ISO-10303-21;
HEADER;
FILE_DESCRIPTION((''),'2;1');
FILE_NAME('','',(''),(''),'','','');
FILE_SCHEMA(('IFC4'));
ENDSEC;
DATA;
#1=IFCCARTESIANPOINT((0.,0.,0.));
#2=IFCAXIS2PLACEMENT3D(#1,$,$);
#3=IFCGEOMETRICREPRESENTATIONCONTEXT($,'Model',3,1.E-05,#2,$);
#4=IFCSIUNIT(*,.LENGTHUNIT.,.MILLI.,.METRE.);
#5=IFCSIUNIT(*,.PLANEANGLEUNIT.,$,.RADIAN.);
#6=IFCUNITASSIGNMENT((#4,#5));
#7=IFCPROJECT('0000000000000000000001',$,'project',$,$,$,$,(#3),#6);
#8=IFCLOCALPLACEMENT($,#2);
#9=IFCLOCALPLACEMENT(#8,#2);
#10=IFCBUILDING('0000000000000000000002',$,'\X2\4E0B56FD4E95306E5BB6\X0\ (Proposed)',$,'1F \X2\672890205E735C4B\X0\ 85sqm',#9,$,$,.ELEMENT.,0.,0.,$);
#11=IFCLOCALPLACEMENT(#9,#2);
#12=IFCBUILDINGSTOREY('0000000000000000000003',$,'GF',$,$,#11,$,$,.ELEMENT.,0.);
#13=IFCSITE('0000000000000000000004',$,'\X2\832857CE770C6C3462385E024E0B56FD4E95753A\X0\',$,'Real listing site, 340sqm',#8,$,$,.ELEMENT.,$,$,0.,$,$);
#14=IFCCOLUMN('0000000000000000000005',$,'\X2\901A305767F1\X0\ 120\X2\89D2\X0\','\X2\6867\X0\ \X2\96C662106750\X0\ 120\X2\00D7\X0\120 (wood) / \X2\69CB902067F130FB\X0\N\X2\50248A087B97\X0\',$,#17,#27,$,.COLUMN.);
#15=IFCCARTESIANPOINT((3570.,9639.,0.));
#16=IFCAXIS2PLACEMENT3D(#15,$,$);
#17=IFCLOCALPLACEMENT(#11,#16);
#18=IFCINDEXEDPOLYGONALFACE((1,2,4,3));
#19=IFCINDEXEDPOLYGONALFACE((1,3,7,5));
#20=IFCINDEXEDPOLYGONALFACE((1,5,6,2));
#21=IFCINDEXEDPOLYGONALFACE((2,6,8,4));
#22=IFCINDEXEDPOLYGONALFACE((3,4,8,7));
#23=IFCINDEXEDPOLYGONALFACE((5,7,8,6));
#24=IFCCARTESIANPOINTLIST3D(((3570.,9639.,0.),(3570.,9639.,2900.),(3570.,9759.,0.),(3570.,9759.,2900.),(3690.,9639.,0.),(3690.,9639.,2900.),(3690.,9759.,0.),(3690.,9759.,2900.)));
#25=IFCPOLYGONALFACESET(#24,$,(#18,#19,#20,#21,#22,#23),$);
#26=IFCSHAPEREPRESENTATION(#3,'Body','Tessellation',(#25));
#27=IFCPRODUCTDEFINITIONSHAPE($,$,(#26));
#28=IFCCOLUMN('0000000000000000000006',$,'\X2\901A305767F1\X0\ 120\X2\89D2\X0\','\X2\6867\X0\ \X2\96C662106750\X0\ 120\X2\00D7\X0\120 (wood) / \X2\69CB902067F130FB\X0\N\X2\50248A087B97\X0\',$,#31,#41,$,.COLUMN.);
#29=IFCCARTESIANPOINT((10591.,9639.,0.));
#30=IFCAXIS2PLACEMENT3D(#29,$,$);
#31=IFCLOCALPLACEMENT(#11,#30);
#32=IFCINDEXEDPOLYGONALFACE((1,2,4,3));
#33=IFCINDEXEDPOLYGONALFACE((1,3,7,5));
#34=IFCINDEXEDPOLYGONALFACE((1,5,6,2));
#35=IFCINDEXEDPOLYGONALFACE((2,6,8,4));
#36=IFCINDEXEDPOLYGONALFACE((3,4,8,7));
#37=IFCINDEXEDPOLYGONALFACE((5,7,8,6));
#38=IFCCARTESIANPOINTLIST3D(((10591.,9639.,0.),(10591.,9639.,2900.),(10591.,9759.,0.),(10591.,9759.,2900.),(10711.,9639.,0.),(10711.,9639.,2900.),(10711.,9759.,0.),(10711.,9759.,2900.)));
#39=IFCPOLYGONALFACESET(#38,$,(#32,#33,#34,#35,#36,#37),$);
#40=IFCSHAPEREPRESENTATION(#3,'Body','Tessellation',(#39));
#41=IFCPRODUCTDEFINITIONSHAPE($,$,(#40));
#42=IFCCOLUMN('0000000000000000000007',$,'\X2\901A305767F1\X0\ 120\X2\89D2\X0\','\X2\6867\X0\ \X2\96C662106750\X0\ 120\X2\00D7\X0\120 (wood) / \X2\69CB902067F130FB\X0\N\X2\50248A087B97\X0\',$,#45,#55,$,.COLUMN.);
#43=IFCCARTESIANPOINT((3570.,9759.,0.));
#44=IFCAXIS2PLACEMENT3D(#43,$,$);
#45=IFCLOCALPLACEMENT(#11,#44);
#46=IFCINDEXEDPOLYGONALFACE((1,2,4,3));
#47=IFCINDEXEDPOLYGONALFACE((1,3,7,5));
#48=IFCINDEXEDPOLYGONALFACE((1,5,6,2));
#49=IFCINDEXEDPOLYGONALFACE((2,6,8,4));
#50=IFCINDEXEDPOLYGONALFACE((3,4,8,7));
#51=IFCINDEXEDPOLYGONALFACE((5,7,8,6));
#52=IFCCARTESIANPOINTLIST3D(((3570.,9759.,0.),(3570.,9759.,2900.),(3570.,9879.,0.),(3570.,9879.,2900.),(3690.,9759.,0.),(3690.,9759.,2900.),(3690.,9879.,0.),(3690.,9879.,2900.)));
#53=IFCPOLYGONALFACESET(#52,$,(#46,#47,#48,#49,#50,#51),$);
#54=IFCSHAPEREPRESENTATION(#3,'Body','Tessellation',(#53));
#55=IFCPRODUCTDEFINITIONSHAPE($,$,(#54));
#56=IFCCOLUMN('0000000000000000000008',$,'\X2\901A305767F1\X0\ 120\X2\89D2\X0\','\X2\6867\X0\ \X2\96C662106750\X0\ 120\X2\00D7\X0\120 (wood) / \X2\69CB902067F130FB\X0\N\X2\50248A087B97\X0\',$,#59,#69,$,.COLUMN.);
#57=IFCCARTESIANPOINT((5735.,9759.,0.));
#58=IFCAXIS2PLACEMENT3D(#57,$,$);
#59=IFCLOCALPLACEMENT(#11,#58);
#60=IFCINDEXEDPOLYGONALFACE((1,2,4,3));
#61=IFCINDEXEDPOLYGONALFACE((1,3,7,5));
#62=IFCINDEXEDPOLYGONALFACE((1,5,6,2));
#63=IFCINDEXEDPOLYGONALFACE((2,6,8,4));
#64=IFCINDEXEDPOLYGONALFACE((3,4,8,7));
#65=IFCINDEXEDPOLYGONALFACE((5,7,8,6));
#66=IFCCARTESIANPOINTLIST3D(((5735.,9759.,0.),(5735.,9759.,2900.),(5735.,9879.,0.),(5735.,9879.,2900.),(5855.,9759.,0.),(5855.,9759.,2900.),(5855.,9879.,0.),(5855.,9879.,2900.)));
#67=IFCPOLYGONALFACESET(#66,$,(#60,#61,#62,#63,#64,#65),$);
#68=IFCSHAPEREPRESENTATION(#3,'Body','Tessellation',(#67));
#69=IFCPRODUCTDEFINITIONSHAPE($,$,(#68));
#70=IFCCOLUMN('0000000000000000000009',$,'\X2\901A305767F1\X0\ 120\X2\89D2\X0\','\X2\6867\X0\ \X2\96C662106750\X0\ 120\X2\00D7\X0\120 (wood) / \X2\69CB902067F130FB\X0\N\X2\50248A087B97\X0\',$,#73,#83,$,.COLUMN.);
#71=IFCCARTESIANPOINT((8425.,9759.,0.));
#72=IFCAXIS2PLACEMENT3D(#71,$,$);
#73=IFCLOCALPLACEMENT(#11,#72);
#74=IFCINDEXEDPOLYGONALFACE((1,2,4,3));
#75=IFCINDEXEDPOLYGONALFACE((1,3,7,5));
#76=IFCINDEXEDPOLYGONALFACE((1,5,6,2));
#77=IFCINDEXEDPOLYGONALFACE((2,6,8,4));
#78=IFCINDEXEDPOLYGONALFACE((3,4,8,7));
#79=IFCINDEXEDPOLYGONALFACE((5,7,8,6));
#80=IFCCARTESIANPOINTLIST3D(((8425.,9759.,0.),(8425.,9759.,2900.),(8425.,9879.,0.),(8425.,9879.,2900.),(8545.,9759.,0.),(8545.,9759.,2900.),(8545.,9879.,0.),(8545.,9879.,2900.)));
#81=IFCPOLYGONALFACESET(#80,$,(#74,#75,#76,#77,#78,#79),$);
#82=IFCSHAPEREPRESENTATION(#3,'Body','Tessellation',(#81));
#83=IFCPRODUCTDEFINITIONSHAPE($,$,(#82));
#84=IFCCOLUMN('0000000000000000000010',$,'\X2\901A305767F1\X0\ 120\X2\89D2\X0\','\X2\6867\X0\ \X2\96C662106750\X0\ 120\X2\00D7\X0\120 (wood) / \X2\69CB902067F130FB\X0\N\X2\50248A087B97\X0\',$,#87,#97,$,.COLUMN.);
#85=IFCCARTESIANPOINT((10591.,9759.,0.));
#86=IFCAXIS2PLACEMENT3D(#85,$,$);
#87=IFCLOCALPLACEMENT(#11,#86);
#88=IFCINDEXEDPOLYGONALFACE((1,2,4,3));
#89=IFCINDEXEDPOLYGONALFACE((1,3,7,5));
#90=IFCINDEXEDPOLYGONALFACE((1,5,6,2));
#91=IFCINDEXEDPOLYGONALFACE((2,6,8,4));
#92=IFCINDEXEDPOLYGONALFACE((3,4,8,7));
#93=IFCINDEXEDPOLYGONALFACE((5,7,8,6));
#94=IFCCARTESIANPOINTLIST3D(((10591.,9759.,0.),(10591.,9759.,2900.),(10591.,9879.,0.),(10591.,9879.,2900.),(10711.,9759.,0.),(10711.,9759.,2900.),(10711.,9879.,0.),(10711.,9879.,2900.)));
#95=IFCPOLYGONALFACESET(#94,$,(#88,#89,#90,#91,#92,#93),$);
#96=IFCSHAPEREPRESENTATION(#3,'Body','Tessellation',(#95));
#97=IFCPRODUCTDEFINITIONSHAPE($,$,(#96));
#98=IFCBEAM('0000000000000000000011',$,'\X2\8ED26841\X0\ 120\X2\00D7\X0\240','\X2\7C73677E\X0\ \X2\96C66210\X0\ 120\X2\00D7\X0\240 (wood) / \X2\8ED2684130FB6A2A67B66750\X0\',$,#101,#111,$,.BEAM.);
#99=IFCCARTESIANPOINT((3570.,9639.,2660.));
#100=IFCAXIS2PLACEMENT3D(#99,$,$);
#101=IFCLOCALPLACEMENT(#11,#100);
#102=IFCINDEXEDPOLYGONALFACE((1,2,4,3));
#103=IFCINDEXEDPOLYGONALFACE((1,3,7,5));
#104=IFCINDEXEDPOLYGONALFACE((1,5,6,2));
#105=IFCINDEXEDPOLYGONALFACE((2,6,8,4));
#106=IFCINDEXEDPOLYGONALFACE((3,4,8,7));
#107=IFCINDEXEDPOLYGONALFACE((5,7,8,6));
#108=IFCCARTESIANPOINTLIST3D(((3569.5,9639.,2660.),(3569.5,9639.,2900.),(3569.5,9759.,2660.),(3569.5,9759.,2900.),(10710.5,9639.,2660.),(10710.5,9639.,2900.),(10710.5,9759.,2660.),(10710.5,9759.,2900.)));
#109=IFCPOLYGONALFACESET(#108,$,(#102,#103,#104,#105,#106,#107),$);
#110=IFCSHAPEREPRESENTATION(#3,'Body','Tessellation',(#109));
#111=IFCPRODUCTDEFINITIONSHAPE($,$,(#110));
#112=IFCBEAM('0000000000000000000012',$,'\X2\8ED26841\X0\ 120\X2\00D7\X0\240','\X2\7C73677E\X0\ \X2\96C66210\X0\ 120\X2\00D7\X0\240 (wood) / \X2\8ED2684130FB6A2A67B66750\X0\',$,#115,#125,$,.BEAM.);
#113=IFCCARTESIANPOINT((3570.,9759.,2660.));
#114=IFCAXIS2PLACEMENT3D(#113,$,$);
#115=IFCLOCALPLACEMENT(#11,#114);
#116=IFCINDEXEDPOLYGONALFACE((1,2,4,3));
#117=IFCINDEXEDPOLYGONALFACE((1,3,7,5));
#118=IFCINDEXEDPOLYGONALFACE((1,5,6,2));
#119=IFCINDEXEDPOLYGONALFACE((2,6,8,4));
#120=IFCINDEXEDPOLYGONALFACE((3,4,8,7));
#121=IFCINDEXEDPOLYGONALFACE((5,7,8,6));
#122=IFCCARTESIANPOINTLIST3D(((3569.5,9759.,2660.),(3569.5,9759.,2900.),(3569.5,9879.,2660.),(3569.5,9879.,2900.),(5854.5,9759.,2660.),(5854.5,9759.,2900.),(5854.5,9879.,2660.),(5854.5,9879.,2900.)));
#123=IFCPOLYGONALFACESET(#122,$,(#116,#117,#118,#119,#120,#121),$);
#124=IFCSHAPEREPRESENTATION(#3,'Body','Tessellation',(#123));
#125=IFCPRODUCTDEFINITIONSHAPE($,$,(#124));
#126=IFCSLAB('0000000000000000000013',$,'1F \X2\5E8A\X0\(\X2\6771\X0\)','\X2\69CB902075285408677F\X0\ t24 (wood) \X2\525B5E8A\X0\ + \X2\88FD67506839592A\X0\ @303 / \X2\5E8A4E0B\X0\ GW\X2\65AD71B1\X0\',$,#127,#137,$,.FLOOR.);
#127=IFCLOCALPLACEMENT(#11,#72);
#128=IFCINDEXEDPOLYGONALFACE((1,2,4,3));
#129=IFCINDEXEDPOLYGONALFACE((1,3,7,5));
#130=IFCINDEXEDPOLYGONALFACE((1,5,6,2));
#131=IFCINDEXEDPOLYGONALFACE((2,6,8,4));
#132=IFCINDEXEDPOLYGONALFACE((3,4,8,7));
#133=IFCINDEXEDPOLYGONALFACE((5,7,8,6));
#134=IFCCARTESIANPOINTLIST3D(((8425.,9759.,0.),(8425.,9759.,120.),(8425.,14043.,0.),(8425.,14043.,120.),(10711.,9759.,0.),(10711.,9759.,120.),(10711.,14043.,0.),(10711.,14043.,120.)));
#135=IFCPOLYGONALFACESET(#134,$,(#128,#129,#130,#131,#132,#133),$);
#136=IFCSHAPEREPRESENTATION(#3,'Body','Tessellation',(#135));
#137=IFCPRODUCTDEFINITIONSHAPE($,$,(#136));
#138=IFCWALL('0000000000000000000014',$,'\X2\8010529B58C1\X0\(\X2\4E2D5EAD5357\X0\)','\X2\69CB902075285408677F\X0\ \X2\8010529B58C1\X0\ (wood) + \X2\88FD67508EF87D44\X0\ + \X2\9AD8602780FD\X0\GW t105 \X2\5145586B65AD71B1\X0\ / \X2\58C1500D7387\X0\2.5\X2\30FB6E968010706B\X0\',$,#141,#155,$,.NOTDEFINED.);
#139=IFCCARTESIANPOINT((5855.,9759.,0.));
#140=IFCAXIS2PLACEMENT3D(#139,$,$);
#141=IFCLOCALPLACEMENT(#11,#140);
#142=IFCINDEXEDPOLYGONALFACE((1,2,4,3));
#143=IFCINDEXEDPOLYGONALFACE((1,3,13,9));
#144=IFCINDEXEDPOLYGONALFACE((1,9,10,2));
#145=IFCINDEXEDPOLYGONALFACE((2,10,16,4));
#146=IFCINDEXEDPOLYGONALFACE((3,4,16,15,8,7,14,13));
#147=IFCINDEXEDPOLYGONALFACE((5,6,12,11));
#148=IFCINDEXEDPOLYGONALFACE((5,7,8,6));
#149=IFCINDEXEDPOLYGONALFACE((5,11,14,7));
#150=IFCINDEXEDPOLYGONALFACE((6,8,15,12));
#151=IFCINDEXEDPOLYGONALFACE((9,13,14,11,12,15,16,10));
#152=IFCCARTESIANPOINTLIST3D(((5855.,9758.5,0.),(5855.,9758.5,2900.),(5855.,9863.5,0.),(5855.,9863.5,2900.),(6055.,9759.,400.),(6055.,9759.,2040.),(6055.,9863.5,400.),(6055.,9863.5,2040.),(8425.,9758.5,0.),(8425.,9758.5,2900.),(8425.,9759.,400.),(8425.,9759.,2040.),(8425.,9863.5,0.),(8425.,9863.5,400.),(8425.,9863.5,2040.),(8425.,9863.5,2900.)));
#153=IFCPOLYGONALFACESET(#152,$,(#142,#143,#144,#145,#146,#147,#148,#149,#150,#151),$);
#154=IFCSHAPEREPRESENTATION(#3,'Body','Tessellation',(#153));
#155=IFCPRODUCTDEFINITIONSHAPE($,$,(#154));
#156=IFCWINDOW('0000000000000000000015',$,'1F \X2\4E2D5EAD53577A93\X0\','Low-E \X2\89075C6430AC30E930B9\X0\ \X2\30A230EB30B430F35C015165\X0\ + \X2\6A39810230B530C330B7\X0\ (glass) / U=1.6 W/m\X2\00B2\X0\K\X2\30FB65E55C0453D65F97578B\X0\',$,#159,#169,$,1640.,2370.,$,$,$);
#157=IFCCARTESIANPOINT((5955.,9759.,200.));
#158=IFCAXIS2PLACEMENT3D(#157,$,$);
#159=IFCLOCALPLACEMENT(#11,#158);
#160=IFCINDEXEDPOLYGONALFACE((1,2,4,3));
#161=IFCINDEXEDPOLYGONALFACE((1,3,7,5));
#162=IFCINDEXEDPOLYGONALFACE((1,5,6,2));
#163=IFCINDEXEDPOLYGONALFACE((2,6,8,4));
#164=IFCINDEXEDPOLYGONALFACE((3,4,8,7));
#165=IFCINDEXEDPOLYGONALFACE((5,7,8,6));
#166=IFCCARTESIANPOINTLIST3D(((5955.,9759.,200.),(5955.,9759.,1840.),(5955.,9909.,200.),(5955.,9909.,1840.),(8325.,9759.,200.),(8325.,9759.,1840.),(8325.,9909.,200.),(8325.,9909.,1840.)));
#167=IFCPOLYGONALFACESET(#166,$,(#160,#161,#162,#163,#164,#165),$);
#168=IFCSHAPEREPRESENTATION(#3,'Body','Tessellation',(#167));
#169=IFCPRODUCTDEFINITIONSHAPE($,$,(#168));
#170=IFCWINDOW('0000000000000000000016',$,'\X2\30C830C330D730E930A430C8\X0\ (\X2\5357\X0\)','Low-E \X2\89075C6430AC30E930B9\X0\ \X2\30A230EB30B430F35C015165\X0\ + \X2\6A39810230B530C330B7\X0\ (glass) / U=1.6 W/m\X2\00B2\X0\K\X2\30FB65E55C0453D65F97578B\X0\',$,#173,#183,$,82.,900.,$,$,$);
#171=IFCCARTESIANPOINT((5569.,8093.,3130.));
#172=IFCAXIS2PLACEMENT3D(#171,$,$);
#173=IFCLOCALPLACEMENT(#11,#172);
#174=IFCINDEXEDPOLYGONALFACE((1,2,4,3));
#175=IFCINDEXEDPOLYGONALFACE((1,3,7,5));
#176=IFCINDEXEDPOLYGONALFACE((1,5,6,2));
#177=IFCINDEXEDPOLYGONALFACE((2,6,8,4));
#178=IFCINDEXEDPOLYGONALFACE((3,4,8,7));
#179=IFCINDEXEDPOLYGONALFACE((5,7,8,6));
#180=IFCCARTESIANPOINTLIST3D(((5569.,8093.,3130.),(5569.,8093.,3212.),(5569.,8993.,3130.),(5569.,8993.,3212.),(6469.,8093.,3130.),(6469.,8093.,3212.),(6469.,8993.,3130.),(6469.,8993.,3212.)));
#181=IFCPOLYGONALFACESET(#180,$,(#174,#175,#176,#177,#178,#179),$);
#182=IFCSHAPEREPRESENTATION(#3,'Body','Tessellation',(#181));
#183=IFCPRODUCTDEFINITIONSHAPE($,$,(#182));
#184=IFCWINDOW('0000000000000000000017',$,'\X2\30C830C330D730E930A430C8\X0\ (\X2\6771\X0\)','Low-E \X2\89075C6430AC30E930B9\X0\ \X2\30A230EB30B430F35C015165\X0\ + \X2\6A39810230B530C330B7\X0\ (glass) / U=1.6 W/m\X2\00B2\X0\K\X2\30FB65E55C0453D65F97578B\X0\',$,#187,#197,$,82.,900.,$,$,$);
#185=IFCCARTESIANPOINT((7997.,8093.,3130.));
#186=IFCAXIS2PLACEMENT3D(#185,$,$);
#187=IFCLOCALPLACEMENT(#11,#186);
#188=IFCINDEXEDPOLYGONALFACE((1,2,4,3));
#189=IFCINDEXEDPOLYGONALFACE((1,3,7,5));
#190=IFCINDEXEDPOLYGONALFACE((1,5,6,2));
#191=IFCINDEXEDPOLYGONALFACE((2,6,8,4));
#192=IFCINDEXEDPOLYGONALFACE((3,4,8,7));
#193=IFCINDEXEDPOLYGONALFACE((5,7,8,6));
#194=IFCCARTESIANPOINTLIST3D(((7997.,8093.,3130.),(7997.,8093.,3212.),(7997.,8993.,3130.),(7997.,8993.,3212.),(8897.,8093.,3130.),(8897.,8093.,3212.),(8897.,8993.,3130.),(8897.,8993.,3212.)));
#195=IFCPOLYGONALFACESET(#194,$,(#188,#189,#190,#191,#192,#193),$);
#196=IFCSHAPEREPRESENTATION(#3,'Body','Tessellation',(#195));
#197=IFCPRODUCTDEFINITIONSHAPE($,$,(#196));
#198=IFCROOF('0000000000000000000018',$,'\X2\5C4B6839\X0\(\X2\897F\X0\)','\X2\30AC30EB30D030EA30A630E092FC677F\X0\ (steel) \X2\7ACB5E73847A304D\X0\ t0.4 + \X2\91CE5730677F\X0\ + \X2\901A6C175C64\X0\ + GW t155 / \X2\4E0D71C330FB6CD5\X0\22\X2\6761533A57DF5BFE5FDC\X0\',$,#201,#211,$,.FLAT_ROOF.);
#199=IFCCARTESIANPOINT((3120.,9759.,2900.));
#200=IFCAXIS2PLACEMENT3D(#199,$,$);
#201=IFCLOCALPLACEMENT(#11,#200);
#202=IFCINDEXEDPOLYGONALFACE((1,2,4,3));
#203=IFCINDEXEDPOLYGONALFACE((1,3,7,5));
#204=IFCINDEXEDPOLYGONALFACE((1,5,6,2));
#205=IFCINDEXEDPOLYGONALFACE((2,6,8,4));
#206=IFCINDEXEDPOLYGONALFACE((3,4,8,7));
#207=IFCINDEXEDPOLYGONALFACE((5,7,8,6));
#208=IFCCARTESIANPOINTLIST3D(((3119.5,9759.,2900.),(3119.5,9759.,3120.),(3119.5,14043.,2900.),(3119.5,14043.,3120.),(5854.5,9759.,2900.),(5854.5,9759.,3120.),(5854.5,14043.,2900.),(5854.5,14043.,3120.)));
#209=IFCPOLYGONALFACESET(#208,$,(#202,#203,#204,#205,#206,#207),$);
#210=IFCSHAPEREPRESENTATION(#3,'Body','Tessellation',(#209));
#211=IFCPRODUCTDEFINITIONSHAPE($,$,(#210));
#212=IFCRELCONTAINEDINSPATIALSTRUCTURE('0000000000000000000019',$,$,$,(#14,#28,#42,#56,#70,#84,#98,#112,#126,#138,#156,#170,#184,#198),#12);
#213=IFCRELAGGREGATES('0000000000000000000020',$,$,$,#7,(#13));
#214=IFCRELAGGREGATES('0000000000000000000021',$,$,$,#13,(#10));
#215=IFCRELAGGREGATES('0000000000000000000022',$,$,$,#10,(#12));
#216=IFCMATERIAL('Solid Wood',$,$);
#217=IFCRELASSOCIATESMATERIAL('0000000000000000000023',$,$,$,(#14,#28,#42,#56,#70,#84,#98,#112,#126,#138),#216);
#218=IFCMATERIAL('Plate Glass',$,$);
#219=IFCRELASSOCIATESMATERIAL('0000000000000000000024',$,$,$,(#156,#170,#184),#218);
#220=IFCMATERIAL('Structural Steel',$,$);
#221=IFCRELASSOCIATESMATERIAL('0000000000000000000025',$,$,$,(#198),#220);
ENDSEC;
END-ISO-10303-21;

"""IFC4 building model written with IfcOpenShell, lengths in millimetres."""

from ifc_helpers import new_model, si_unit, frame, frame_2d, origin, place, context, project, spatial, rectangle, extrude, material, element, fill, save


model = new_model("IFC4")

# Units and contexts
model_context = context("Model", 3, precision=1e-05, world=origin())
ifc_project = project(units=[si_unit("LENGTHUNIT", "METRE", prefix="MILLI"), si_unit("PLANEANGLEUNIT", "RADIAN")], contexts=[model_context])

# Site, building, storey
site_placement = place(None, origin())
site = spatial("IfcSite", under=ifc_project, at=site_placement, Name="茨城県水戸市下国井町", ObjectType="Real listing site, 340sqm", CompositionType="ELEMENT", RefElevation=0.0)
building_placement = place(site_placement, origin())
building = spatial("IfcBuilding", under=site, at=building_placement, Name="下国井の家 (Proposed)", ObjectType="1F 木造平屋 85sqm", CompositionType="ELEMENT", ElevationOfRefHeight=0.0, ElevationOfTerrain=0.0)
storey_placement = place(building_placement, origin())
storey = spatial("IfcBuildingStorey", under=building, at=storey_placement, Name="GF", CompositionType="ELEMENT", Elevation=0.0)

# Columns
ifc_material_1 = material(Name="Solid Wood")
column_1_placement = place(storey_placement, frame((3570.0, 9639.0, 0.0)))
element("IfcColumn", 1, at=column_1_placement, inside=storey, material=ifc_material_1, Name="通し柱 120角", Description="桧 集成材 120×120 (wood) / 構造柱・N値計算", PredefinedType="COLUMN", context=model_context, shape_type="SweptSolid", body=[
    extrude(rectangle(XDim=120.0, YDim=120.0, at=frame_2d((60.0, 60.0))), frame((3570.0, 9639.0, 0.0)), (0.0, 0.0, 1.0), 2900.0),
])
column_2_placement = place(storey_placement, frame((10591.0, 9639.0, 0.0)))
element("IfcColumn", 2, at=column_2_placement, inside=storey, material=ifc_material_1, Name="通し柱 120角", Description="桧 集成材 120×120 (wood) / 構造柱・N値計算", PredefinedType="COLUMN", context=model_context, shape_type="SweptSolid", body=[
    extrude(rectangle(XDim=120.0, YDim=120.0, at=frame_2d((60.0, 60.0))), frame((10591.0, 9639.0, 0.0)), (0.0, 0.0, 1.0), 2900.0),
])
column_3_placement = place(storey_placement, frame((3570.0, 9759.0, 0.0)))
element("IfcColumn", 3, at=column_3_placement, inside=storey, material=ifc_material_1, Name="通し柱 120角", Description="桧 集成材 120×120 (wood) / 構造柱・N値計算", PredefinedType="COLUMN", context=model_context, shape_type="SweptSolid", body=[
    extrude(rectangle(XDim=120.0, YDim=120.0, at=frame_2d((60.0, 60.0))), frame((3570.0, 9759.0, 0.0)), (0.0, 0.0, 1.0), 2900.0),
])
column_4_placement = place(storey_placement, frame((5735.0, 9759.0, 0.0)))
element("IfcColumn", 4, at=column_4_placement, inside=storey, material=ifc_material_1, Name="通し柱 120角", Description="桧 集成材 120×120 (wood) / 構造柱・N値計算", PredefinedType="COLUMN", context=model_context, shape_type="SweptSolid", body=[
    extrude(rectangle(XDim=120.0, YDim=120.0, at=frame_2d((60.0, 60.0))), frame((5735.0, 9759.0, 0.0)), (0.0, 0.0, 1.0), 2900.0),
])
column_5_placement = place(storey_placement, frame((8425.0, 9759.0, 0.0)))
element("IfcColumn", 5, at=column_5_placement, inside=storey, material=ifc_material_1, Name="通し柱 120角", Description="桧 集成材 120×120 (wood) / 構造柱・N値計算", PredefinedType="COLUMN", context=model_context, shape_type="SweptSolid", body=[
    extrude(rectangle(XDim=120.0, YDim=120.0, at=frame_2d((60.0, 60.0))), frame((8425.0, 9759.0, 0.0)), (0.0, 0.0, 1.0), 2900.0),
])
column_6_placement = place(storey_placement, frame((10591.0, 9759.0, 0.0)))
element("IfcColumn", 6, at=column_6_placement, inside=storey, material=ifc_material_1, Name="通し柱 120角", Description="桧 集成材 120×120 (wood) / 構造柱・N値計算", PredefinedType="COLUMN", context=model_context, shape_type="SweptSolid", body=[
    extrude(rectangle(XDim=120.0, YDim=120.0, at=frame_2d((60.0, 60.0))), frame((10591.0, 9759.0, 0.0)), (0.0, 0.0, 1.0), 2900.0),
])

# Beams
beam_1_placement = place(storey_placement, frame((3570.0, 9639.0, 2660.0)))
element("IfcBeam", 7, at=beam_1_placement, inside=storey, material=ifc_material_1, Name="軒桁 120×240", Description="米松 集成 120×240 (wood) / 軒桁・横架材", PredefinedType="BEAM", context=model_context, shape_type="SweptSolid", body=[
    extrude(rectangle(XDim=7141.0, YDim=120.0, at=frame_2d((3570.0, 60.0))), frame((3570.0, 9639.0, 2660.0)), (0.0, 0.0, 1.0), 240.0),
])
beam_2_placement = place(storey_placement, frame((3570.0, 9759.0, 2660.0)))
element("IfcBeam", 8, at=beam_2_placement, inside=storey, material=ifc_material_1, Name="軒桁 120×240", Description="米松 集成 120×240 (wood) / 軒桁・横架材", PredefinedType="BEAM", context=model_context, shape_type="SweptSolid", body=[
    extrude(rectangle(XDim=2285.0, YDim=120.0, at=frame_2d((1142.0, 60.0))), frame((3570.0, 9759.0, 2660.0)), (0.0, 0.0, 1.0), 240.0),
])

# Slab
slab_1_placement = place(storey_placement, frame((8425.0, 9759.0, 0.0)))
element("IfcSlab", 9, at=slab_1_placement, inside=storey, material=ifc_material_1, Name="1F 床(東)", Description="構造用合板 t24 (wood) 剛床 + 製材根太 @303 / 床下 GW断熱", PredefinedType="FLOOR", context=model_context, shape_type="SweptSolid", body=[
    extrude(rectangle(XDim=2286.0, YDim=4284.0, at=frame_2d((1143.0, 2142.0))), frame((8425.0, 9759.0, 0.0)), (0.0, 0.0, 1.0), 120.0),
])

# Wall, opening, window
wall_1_placement = place(storey_placement, frame((5855.0, 9759.0, 0.0)))
wall_1 = element("IfcWall", 10, at=wall_1_placement, inside=storey, material=ifc_material_1, Name="耐力壁(中庭南)", Description="構造用合板 耐力壁 (wood) + 製材軸組 + 高性能GW t105 充填断熱 / 壁倍率2.5・準耐火", PredefinedType="NOTDEFINED", context=model_context, shape_type="SweptSolid", body=[
    extrude(rectangle(XDim=2570.0, YDim=105.0, at=frame_2d((1285.0, 52.0))), frame((5855.0, 9759.0, 0.0)), (0.0, 0.0, 1.0), 2900.0),
])
opening_placement = place(storey_placement, frame((5955.0, 9759.0, 200.0)))
opening = element("IfcOpeningElement", 11, at=opening_placement, cuts=wall_1, PredefinedType="NOTDEFINED", context=model_context, shape_type="SweptSolid", body=[
    extrude(rectangle(XDim=2370.0, YDim=150.0, at=frame_2d((1185.0, 75.0))), frame((5955.0, 9759.0, 200.0)), (0.0, 0.0, 1.0), 1640.0),
])
ifc_material_2 = material(Name="Plate Glass")
window_1_placement = place(storey_placement, frame((5955.0, 9759.0, 200.0)))
window_1 = element("IfcWindow", 12, at=window_1_placement, inside=storey, material=ifc_material_2, Name="1F 中庭南窓", Description="Low-E 複層ガラス アルゴン封入 + 樹脂サッシ (glass) / U=1.6 W/m²K・日射取得型", OverallHeight=1640.0, OverallWidth=2370.0, context=model_context, shape_type="SweptSolid", body=[
    extrude(rectangle(XDim=2370.0, YDim=150.0, at=frame_2d((1185.0, 75.0))), frame((5955.0, 9759.0, 200.0)), (0.0, 0.0, 1.0), 1640.0),
])
fill(opening, window_1)

# Windows
window_2_placement = place(storey_placement, frame((5569.0, 8093.0, 3130.0)))
element("IfcWindow", 13, at=window_2_placement, inside=storey, material=ifc_material_2, Name="トップライト (南)", Description="Low-E 複層ガラス アルゴン封入 + 樹脂サッシ (glass) / U=1.6 W/m²K・日射取得型", OverallHeight=82.0, OverallWidth=900.0, context=model_context, shape_type="SweptSolid", body=[
    extrude(rectangle(XDim=900.0, YDim=900.0, at=frame_2d((450.0, 450.0))), frame((5569.0, 8093.0, 3130.0)), (0.0, 0.0, 1.0), 82.0),
])
window_3_placement = place(storey_placement, frame((7997.0, 8093.0, 3130.0)))
element("IfcWindow", 14, at=window_3_placement, inside=storey, material=ifc_material_2, Name="トップライト (東)", Description="Low-E 複層ガラス アルゴン封入 + 樹脂サッシ (glass) / U=1.6 W/m²K・日射取得型", OverallHeight=82.0, OverallWidth=900.0, context=model_context, shape_type="SweptSolid", body=[
    extrude(rectangle(XDim=900.0, YDim=900.0, at=frame_2d((450.0, 450.0))), frame((7997.0, 8093.0, 3130.0)), (0.0, 0.0, 1.0), 82.0),
])

# Roof
ifc_material_3 = material(Name="Structural Steel")
roof_1_placement = place(storey_placement, frame((3120.0, 9759.0, 2900.0)))
element("IfcRoof", 15, at=roof_1_placement, inside=storey, material=ifc_material_3, Name="屋根(西)", Description="ガルバリウム鋼板 (steel) 立平葺き t0.4 + 野地板 + 通気層 + GW t155 / 不燃・法22条区域対応", PredefinedType="FLAT_ROOF", context=model_context, shape_type="SweptSolid", body=[
    extrude(rectangle(XDim=2735.0, YDim=4284.0, at=frame_2d((1367.0, 2142.0))), frame((3120.0, 9759.0, 2900.0)), (0.0, 0.0, 1.0), 220.0),
])

save(model, "model.ifc")
